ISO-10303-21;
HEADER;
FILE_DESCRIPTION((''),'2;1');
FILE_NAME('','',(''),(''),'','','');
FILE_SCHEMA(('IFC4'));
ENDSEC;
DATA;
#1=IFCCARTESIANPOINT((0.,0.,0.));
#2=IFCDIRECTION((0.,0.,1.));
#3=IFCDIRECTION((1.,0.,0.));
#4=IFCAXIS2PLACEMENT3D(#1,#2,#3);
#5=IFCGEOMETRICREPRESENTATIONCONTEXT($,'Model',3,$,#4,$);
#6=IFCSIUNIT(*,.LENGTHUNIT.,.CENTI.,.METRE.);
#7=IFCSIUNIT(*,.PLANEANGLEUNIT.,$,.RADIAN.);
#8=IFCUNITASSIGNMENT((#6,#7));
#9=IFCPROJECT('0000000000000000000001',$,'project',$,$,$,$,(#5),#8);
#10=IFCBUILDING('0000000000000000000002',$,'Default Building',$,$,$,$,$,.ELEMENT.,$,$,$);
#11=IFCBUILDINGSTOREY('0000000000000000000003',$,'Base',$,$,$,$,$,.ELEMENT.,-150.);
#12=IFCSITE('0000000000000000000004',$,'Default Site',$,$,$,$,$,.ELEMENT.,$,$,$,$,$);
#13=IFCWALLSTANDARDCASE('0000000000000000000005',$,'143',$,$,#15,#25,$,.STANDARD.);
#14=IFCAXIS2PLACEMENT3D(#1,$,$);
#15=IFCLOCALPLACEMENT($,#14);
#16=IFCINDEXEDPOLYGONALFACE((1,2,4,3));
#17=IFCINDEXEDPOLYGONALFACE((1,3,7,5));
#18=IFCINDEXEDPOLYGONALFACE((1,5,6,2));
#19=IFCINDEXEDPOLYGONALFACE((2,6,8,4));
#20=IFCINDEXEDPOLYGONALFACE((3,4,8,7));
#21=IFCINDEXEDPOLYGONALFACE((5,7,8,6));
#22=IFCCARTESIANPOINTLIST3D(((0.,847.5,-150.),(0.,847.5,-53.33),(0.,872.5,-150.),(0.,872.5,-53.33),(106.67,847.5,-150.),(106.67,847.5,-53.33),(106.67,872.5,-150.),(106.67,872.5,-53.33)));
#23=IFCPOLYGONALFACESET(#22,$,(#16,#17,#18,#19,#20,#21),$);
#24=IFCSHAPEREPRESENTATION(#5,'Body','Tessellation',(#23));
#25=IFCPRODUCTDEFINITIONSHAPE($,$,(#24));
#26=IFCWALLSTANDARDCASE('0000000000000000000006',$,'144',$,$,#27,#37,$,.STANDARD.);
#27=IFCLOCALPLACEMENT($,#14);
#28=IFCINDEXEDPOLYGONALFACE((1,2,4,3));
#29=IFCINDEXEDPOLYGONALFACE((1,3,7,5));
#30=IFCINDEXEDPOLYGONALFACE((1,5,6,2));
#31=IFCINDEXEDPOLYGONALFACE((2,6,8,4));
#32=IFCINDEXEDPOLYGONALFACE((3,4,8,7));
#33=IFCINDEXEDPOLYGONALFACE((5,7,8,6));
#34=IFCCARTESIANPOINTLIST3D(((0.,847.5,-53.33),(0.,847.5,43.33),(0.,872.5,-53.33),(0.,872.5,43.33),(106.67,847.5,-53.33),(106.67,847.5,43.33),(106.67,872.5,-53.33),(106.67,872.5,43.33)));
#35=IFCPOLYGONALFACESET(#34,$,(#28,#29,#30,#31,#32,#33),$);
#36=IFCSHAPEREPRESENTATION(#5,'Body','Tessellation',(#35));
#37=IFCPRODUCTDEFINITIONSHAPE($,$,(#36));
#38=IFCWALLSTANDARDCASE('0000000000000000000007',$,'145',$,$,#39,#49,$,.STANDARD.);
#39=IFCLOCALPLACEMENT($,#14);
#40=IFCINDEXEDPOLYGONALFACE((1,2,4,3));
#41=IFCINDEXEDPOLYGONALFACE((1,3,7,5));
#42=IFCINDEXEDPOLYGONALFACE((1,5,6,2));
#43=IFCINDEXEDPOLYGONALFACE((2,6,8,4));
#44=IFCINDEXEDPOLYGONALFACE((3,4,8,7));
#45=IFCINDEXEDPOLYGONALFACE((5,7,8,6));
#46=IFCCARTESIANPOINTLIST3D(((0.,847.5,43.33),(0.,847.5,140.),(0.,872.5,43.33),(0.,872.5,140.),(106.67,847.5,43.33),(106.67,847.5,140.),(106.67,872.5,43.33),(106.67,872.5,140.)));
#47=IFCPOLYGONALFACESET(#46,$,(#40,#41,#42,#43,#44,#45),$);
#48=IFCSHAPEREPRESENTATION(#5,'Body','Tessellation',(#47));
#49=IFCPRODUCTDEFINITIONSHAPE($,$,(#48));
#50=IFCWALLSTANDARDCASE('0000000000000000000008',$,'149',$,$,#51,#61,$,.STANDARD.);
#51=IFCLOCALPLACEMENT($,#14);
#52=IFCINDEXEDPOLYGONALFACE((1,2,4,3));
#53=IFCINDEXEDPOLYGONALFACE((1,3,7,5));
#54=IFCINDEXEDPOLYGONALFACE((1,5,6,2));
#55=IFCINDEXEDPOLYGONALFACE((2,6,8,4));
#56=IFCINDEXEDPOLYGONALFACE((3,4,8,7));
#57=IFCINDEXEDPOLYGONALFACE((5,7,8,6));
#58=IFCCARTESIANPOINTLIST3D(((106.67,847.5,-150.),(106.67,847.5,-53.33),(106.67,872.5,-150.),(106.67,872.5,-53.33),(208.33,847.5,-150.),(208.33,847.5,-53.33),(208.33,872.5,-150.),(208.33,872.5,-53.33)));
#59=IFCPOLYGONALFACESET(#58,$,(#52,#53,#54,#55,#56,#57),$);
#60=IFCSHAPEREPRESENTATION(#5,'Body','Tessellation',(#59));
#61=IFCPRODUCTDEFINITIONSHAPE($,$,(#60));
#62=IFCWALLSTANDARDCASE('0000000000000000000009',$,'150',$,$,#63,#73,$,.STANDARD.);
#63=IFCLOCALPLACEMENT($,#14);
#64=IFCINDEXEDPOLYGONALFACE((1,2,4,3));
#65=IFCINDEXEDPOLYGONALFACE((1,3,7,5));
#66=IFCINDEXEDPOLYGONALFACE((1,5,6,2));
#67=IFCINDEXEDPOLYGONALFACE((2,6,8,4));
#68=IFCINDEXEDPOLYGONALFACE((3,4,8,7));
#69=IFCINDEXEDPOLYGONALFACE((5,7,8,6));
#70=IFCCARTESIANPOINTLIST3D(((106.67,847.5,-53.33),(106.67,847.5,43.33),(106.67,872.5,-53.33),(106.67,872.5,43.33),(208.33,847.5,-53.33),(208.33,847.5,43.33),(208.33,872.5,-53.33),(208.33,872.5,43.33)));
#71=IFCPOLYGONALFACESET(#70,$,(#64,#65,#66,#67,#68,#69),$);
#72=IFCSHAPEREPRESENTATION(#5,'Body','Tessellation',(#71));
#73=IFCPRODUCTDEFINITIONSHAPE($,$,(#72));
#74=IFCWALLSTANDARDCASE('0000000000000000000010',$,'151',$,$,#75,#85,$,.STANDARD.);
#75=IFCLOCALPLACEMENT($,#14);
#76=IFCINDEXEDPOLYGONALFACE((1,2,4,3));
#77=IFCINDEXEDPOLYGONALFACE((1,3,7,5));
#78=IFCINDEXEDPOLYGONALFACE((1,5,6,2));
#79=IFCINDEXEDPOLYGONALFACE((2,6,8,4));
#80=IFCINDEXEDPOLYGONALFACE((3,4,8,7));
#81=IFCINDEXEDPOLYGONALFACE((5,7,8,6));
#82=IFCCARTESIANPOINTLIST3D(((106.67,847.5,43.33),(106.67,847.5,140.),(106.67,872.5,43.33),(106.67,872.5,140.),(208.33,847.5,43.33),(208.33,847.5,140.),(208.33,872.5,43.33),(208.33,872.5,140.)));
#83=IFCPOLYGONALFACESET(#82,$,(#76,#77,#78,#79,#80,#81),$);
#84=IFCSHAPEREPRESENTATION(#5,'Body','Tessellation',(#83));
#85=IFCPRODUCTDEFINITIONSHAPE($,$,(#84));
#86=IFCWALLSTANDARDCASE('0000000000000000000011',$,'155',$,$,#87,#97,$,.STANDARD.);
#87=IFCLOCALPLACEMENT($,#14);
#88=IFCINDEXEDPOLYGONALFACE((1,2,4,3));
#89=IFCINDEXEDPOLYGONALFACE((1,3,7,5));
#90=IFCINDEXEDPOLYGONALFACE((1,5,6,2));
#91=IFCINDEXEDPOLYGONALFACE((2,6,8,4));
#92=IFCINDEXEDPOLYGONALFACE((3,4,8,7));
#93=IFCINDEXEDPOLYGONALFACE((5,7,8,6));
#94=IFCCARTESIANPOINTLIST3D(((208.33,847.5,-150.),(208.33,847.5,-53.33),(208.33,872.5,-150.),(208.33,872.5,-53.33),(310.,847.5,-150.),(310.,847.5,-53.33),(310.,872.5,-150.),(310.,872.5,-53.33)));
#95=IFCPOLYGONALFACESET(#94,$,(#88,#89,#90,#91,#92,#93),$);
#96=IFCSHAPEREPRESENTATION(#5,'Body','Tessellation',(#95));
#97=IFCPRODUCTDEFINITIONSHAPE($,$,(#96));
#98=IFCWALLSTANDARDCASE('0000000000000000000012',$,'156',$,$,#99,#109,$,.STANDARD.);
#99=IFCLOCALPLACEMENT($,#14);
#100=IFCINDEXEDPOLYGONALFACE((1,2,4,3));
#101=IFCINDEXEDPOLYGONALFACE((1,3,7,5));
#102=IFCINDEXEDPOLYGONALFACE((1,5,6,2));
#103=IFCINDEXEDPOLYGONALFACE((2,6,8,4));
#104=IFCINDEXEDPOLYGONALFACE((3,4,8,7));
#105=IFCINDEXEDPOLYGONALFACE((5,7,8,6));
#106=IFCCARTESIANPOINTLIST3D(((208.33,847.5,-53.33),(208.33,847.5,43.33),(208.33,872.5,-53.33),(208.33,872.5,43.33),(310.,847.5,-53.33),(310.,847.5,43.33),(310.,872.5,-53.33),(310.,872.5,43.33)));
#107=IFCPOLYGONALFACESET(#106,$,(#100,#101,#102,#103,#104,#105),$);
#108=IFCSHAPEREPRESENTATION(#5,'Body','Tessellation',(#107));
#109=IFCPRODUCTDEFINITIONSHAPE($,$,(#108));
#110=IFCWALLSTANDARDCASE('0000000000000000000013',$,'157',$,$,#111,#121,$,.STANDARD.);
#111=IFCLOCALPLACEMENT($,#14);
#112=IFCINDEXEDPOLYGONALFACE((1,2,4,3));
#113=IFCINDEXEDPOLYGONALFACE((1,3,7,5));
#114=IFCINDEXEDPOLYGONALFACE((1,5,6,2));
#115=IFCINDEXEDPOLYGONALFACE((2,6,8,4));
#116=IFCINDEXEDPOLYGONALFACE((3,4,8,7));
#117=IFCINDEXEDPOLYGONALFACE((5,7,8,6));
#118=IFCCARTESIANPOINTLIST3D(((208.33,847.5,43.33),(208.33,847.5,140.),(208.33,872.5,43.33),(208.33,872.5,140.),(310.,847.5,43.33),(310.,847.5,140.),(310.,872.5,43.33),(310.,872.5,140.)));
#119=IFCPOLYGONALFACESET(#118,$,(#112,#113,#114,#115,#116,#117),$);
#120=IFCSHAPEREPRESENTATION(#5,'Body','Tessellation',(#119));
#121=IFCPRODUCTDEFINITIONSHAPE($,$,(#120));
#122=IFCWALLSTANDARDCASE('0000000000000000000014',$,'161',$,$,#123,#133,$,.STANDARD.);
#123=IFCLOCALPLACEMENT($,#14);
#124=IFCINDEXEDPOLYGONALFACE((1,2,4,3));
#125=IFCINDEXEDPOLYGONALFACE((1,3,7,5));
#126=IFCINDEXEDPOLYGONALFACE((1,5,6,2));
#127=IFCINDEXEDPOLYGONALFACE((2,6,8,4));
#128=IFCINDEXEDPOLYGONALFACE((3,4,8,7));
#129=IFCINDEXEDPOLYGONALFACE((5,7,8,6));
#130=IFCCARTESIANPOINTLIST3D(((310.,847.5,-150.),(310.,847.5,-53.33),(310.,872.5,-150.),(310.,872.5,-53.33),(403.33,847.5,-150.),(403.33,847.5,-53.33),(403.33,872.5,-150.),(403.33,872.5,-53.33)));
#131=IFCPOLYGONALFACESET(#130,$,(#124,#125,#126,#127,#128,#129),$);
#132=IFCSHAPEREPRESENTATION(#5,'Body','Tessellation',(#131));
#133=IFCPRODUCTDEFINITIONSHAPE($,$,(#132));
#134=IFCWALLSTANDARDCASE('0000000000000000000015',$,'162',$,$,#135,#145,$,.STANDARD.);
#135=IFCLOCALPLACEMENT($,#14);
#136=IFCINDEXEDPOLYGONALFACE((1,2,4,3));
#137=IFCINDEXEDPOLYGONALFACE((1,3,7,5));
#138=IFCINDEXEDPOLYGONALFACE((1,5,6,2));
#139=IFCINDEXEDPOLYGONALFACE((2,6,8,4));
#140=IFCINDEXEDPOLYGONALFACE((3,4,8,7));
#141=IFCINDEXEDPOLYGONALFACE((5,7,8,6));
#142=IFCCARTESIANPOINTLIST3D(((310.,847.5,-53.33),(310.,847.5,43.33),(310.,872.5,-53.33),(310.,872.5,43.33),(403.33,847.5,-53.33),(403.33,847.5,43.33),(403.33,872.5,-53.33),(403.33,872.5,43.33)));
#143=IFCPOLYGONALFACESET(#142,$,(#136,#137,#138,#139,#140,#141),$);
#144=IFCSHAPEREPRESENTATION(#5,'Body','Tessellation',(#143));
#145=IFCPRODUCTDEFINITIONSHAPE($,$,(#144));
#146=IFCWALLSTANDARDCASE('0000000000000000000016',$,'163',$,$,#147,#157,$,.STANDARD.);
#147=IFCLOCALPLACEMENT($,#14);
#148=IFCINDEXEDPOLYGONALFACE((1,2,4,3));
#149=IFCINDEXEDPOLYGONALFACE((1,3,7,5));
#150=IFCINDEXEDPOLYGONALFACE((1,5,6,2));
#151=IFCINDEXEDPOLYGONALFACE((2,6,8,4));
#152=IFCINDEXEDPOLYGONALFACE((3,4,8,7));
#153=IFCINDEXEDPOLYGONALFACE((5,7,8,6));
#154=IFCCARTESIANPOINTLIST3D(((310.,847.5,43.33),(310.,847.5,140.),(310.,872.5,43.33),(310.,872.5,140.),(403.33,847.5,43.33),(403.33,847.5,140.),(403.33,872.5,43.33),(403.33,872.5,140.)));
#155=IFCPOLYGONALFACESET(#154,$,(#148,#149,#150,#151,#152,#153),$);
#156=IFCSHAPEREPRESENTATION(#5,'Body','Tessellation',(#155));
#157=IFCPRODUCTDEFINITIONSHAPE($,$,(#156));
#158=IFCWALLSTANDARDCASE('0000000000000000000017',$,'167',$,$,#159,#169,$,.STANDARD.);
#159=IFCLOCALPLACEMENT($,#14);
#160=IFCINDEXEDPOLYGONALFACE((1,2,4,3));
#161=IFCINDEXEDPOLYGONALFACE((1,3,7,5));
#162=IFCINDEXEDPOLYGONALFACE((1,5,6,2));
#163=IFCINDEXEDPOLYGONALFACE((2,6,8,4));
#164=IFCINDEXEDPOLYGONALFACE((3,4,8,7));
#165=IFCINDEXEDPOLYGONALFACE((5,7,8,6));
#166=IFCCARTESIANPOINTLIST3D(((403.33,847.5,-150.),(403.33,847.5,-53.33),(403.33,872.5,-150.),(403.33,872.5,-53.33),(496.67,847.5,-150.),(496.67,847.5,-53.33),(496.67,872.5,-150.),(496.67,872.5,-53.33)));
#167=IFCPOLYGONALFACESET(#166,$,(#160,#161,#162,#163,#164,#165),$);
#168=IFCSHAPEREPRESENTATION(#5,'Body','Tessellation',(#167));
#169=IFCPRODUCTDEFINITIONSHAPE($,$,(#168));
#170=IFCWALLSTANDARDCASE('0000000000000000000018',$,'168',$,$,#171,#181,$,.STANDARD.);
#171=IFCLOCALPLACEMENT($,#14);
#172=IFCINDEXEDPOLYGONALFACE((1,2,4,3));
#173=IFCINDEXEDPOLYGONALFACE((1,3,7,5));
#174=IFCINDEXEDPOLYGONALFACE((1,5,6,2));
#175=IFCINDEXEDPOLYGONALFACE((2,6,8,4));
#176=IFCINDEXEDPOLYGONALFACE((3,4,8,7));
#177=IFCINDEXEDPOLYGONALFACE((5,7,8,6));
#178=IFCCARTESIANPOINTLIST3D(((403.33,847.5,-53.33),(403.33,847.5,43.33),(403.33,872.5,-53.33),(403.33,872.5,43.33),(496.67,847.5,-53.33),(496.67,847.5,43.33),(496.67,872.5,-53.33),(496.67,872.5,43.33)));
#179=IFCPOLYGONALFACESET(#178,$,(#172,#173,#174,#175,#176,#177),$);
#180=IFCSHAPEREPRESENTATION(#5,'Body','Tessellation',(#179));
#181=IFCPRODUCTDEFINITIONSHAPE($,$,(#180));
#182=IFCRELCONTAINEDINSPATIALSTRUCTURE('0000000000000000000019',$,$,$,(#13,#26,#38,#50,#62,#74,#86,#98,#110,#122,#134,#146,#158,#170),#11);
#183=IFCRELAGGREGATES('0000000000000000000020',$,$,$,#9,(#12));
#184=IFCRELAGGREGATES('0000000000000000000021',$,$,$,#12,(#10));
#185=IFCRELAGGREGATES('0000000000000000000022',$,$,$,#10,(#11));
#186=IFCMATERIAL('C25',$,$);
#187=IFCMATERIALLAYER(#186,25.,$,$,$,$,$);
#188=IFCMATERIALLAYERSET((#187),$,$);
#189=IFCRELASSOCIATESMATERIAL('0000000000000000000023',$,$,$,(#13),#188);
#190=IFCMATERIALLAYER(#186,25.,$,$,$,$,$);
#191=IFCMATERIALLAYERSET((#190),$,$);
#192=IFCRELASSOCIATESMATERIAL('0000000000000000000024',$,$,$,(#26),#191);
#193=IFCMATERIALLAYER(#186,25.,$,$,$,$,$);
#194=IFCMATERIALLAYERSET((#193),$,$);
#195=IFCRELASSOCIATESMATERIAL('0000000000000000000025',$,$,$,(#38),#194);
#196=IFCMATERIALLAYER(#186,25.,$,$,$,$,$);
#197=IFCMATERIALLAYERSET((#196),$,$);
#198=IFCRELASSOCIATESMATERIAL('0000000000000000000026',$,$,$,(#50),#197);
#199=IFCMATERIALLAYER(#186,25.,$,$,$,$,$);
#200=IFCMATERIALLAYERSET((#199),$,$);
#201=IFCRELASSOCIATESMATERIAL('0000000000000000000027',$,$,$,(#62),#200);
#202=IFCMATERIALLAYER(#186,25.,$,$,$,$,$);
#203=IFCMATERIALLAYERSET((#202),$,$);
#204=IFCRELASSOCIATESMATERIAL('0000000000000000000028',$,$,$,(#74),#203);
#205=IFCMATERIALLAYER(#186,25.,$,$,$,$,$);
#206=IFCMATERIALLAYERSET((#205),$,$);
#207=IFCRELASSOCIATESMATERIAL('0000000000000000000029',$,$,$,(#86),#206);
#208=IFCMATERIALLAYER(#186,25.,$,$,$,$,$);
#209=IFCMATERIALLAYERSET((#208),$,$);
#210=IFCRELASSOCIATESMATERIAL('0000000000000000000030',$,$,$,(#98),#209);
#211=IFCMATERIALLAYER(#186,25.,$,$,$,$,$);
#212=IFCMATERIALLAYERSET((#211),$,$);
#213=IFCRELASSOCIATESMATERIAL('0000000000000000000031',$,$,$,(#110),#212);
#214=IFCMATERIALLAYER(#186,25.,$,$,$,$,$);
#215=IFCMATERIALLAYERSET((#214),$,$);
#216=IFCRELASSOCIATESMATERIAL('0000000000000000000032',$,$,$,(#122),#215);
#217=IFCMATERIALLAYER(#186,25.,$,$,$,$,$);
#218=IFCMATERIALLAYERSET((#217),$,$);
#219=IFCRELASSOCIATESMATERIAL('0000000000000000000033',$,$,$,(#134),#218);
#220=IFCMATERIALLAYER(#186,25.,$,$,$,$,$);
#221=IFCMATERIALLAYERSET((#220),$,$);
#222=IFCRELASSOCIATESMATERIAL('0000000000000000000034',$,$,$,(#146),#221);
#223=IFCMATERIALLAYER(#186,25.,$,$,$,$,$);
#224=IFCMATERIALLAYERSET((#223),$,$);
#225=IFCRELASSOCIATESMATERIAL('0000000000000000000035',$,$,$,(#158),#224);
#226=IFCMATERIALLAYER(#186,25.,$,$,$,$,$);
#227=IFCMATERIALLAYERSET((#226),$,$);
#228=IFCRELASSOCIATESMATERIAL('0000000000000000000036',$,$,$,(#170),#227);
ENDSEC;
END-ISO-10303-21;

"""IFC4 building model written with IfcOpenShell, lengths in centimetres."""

from ifc_helpers import new_model, si_unit, frame, origin_with_axes, origin_2d_with_axis, place, context, project, spatial, rectangle, extrude, material, layer, layer_set, layer_usage, element, save


model = new_model("IFC4")

# Units and contexts
model_context = context("Model", 3, world=origin_with_axes())
ifc_project = project(units=[si_unit("LENGTHUNIT", "METRE", prefix="CENTI"), si_unit("PLANEANGLEUNIT", "RADIAN")], contexts=[model_context])

# Site, building, storey
site = spatial("IfcSite", under=ifc_project, Name="Default Site", CompositionType="ELEMENT")
building = spatial("IfcBuilding", under=site, Name="Default Building", CompositionType="ELEMENT")
storey = spatial("IfcBuildingStorey", under=building, Name="Base", CompositionType="ELEMENT", Elevation=-150.0)

# Shared definitions
ifc_material = material(Name="C25")

# Walls
ifc_layer_1 = layer(ifc_material, 25.0)
ifc_layer_set_1 = layer_set([ifc_layer_1])
ifc_layer_usage_1 = layer_usage(ifc_layer_set_1, "AXIS2", "POSITIVE", -25.0)
wall_1_placement = place(None, frame((53.33, 860.0, -150.0), z_axis=(0.0, 0.0, 1.0), x_axis=(1.0, 0.0, 0.0)))
element("IfcWallStandardCase", 1, at=wall_1_placement, inside=storey, material=ifc_layer_usage_1, Name="143", PredefinedType="STANDARD", context=model_context, shape_type="SweptSolid", body=[
    extrude(rectangle(XDim=106.67, YDim=25.0, at=origin_2d_with_axis()), origin_with_axes(), (0.0, 0.0, 1.0), 96.67),
])
ifc_layer_2 = layer(ifc_material, 25.0)
ifc_layer_set_2 = layer_set([ifc_layer_2])
ifc_layer_usage_2 = layer_usage(ifc_layer_set_2, "AXIS2", "POSITIVE", -25.0)
wall_2_placement = place(None, frame((53.33, 860.0, -53.33), z_axis=(0.0, 0.0, 1.0), x_axis=(1.0, 0.0, 0.0)))
element("IfcWallStandardCase", 2, at=wall_2_placement, inside=storey, material=ifc_layer_usage_2, Name="144", PredefinedType="STANDARD", context=model_context, shape_type="SweptSolid", body=[
    extrude(rectangle(XDim=106.67, YDim=25.0, at=origin_2d_with_axis()), origin_with_axes(), (0.0, 0.0, 1.0), 96.67),
])
ifc_layer_3 = layer(ifc_material, 25.0)
ifc_layer_set_3 = layer_set([ifc_layer_3])
ifc_layer_usage_3 = layer_usage(ifc_layer_set_3, "AXIS2", "POSITIVE", -25.0)
wall_3_placement = place(None, frame((53.33, 860.0, 43.33), z_axis=(0.0, 0.0, 1.0), x_axis=(1.0, 0.0, 0.0)))
element("IfcWallStandardCase", 3, at=wall_3_placement, inside=storey, material=ifc_layer_usage_3, Name="145", PredefinedType="STANDARD", context=model_context, shape_type="SweptSolid", body=[
    extrude(rectangle(XDim=106.67, YDim=25.0, at=origin_2d_with_axis()), origin_with_axes(), (0.0, 0.0, 1.0), 96.67),
])
ifc_layer_4 = layer(ifc_material, 25.0)
ifc_layer_set_4 = layer_set([ifc_layer_4])
ifc_layer_usage_4 = layer_usage(ifc_layer_set_4, "AXIS2", "POSITIVE", -25.0)
wall_4_placement = place(None, frame((157.5, 860.0, -150.0), z_axis=(0.0, 0.0, 1.0), x_axis=(1.0, 0.0, 0.0)))
element("IfcWallStandardCase", 4, at=wall_4_placement, inside=storey, material=ifc_layer_usage_4, Name="149", PredefinedType="STANDARD", context=model_context, shape_type="SweptSolid", body=[
    extrude(rectangle(XDim=101.67, YDim=25.0, at=origin_2d_with_axis()), origin_with_axes(), (0.0, 0.0, 1.0), 96.67),
])
ifc_layer_5 = layer(ifc_material, 25.0)
ifc_layer_set_5 = layer_set([ifc_layer_5])
ifc_layer_usage_5 = layer_usage(ifc_layer_set_5, "AXIS2", "POSITIVE", -25.0)
wall_5_placement = place(None, frame((157.5, 860.0, -53.33), z_axis=(0.0, 0.0, 1.0), x_axis=(1.0, 0.0, 0.0)))
element("IfcWallStandardCase", 5, at=wall_5_placement, inside=storey, material=ifc_layer_usage_5, Name="150", PredefinedType="STANDARD", context=model_context, shape_type="SweptSolid", body=[
    extrude(rectangle(XDim=101.67, YDim=25.0, at=origin_2d_with_axis()), origin_with_axes(), (0.0, 0.0, 1.0), 96.67),
])
ifc_layer_6 = layer(ifc_material, 25.0)
ifc_layer_set_6 = layer_set([ifc_layer_6])
ifc_layer_usage_6 = layer_usage(ifc_layer_set_6, "AXIS2", "POSITIVE", -25.0)
wall_6_placement = place(None, frame((157.5, 860.0, 43.33), z_axis=(0.0, 0.0, 1.0), x_axis=(1.0, 0.0, 0.0)))
element("IfcWallStandardCase", 6, at=wall_6_placement, inside=storey, material=ifc_layer_usage_6, Name="151", PredefinedType="STANDARD", context=model_context, shape_type="SweptSolid", body=[
    extrude(rectangle(XDim=101.67, YDim=25.0, at=origin_2d_with_axis()), origin_with_axes(), (0.0, 0.0, 1.0), 96.67),
])
ifc_layer_7 = layer(ifc_material, 25.0)
ifc_layer_set_7 = layer_set([ifc_layer_7])
ifc_layer_usage_7 = layer_usage(ifc_layer_set_7, "AXIS2", "POSITIVE", -25.0)
wall_7_placement = place(None, frame((259.17, 860.0, -150.0), z_axis=(0.0, 0.0, 1.0), x_axis=(1.0, 0.0, 0.0)))
element("IfcWallStandardCase", 7, at=wall_7_placement, inside=storey, material=ifc_layer_usage_7, Name="155", PredefinedType="STANDARD", context=model_context, shape_type="SweptSolid", body=[
    extrude(rectangle(XDim=101.67, YDim=25.0, at=origin_2d_with_axis()), origin_with_axes(), (0.0, 0.0, 1.0), 96.67),
])
ifc_layer_8 = layer(ifc_material, 25.0)
ifc_layer_set_8 = layer_set([ifc_layer_8])
ifc_layer_usage_8 = layer_usage(ifc_layer_set_8, "AXIS2", "POSITIVE", -25.0)
wall_8_placement = place(None, frame((259.17, 860.0, -53.33), z_axis=(0.0, 0.0, 1.0), x_axis=(1.0, 0.0, 0.0)))
element("IfcWallStandardCase", 8, at=wall_8_placement, inside=storey, material=ifc_layer_usage_8, Name="156", PredefinedType="STANDARD", context=model_context, shape_type="SweptSolid", body=[
    extrude(rectangle(XDim=101.67, YDim=25.0, at=origin_2d_with_axis()), origin_with_axes(), (0.0, 0.0, 1.0), 96.67),
])
ifc_layer_9 = layer(ifc_material, 25.0)
ifc_layer_set_9 = layer_set([ifc_layer_9])
ifc_layer_usage_9 = layer_usage(ifc_layer_set_9, "AXIS2", "POSITIVE", -25.0)
wall_9_placement = place(None, frame((259.17, 860.0, 43.33), z_axis=(0.0, 0.0, 1.0), x_axis=(1.0, 0.0, 0.0)))
element("IfcWallStandardCase", 9, at=wall_9_placement, inside=storey, material=ifc_layer_usage_9, Name="157", PredefinedType="STANDARD", context=model_context, shape_type="SweptSolid", body=[
    extrude(rectangle(XDim=101.67, YDim=25.0, at=origin_2d_with_axis()), origin_with_axes(), (0.0, 0.0, 1.0), 96.67),
])
ifc_layer_10 = layer(ifc_material, 25.0)
ifc_layer_set_10 = layer_set([ifc_layer_10])
ifc_layer_usage_10 = layer_usage(ifc_layer_set_10, "AXIS2", "POSITIVE", -25.0)
wall_10_placement = place(None, frame((356.67, 860.0, -150.0), z_axis=(0.0, 0.0, 1.0), x_axis=(1.0, 0.0, 0.0)))
element("IfcWallStandardCase", 10, at=wall_10_placement, inside=storey, material=ifc_layer_usage_10, Name="161", PredefinedType="STANDARD", context=model_context, shape_type="SweptSolid", body=[
    extrude(rectangle(XDim=93.33, YDim=25.0, at=origin_2d_with_axis()), origin_with_axes(), (0.0, 0.0, 1.0), 96.67),
])
ifc_layer_11 = layer(ifc_material, 25.0)
ifc_layer_set_11 = layer_set([ifc_layer_11])
ifc_layer_usage_11 = layer_usage(ifc_layer_set_11, "AXIS2", "POSITIVE", -25.0)
wall_11_placement = place(None, frame((356.67, 860.0, -53.33), z_axis=(0.0, 0.0, 1.0), x_axis=(1.0, 0.0, 0.0)))
element("IfcWallStandardCase", 11, at=wall_11_placement, inside=storey, material=ifc_layer_usage_11, Name="162", PredefinedType="STANDARD", context=model_context, shape_type="SweptSolid", body=[
    extrude(rectangle(XDim=93.33, YDim=25.0, at=origin_2d_with_axis()), origin_with_axes(), (0.0, 0.0, 1.0), 96.67),
])
ifc_layer_12 = layer(ifc_material, 25.0)
ifc_layer_set_12 = layer_set([ifc_layer_12])
ifc_layer_usage_12 = layer_usage(ifc_layer_set_12, "AXIS2", "POSITIVE", -25.0)
wall_12_placement = place(None, frame((356.67, 860.0, 43.33), z_axis=(0.0, 0.0, 1.0), x_axis=(1.0, 0.0, 0.0)))
element("IfcWallStandardCase", 12, at=wall_12_placement, inside=storey, material=ifc_layer_usage_12, Name="163", PredefinedType="STANDARD", context=model_context, shape_type="SweptSolid", body=[
    extrude(rectangle(XDim=93.33, YDim=25.0, at=origin_2d_with_axis()), origin_with_axes(), (0.0, 0.0, 1.0), 96.67),
])
ifc_layer_13 = layer(ifc_material, 25.0)
ifc_layer_set_13 = layer_set([ifc_layer_13])
ifc_layer_usage_13 = layer_usage(ifc_layer_set_13, "AXIS2", "POSITIVE", -25.0)
wall_13_placement = place(None, frame((450.0, 860.0, -150.0), z_axis=(0.0, 0.0, 1.0), x_axis=(1.0, 0.0, 0.0)))
element("IfcWallStandardCase", 13, at=wall_13_placement, inside=storey, material=ifc_layer_usage_13, Name="167", PredefinedType="STANDARD", context=model_context, shape_type="SweptSolid", body=[
    extrude(rectangle(XDim=93.33, YDim=25.0, at=origin_2d_with_axis()), origin_with_axes(), (0.0, 0.0, 1.0), 96.67),
])
ifc_layer_14 = layer(ifc_material, 25.0)
ifc_layer_set_14 = layer_set([ifc_layer_14])
ifc_layer_usage_14 = layer_usage(ifc_layer_set_14, "AXIS2", "POSITIVE", -25.0)
wall_14_placement = place(None, frame((450.0, 860.0, -53.33), z_axis=(0.0, 0.0, 1.0), x_axis=(1.0, 0.0, 0.0)))
element("IfcWallStandardCase", 14, at=wall_14_placement, inside=storey, material=ifc_layer_usage_14, Name="168", PredefinedType="STANDARD", context=model_context, shape_type="SweptSolid", body=[
    extrude(rectangle(XDim=93.33, YDim=25.0, at=origin_2d_with_axis()), origin_with_axes(), (0.0, 0.0, 1.0), 96.67),
])

save(model, "model.ifc")
